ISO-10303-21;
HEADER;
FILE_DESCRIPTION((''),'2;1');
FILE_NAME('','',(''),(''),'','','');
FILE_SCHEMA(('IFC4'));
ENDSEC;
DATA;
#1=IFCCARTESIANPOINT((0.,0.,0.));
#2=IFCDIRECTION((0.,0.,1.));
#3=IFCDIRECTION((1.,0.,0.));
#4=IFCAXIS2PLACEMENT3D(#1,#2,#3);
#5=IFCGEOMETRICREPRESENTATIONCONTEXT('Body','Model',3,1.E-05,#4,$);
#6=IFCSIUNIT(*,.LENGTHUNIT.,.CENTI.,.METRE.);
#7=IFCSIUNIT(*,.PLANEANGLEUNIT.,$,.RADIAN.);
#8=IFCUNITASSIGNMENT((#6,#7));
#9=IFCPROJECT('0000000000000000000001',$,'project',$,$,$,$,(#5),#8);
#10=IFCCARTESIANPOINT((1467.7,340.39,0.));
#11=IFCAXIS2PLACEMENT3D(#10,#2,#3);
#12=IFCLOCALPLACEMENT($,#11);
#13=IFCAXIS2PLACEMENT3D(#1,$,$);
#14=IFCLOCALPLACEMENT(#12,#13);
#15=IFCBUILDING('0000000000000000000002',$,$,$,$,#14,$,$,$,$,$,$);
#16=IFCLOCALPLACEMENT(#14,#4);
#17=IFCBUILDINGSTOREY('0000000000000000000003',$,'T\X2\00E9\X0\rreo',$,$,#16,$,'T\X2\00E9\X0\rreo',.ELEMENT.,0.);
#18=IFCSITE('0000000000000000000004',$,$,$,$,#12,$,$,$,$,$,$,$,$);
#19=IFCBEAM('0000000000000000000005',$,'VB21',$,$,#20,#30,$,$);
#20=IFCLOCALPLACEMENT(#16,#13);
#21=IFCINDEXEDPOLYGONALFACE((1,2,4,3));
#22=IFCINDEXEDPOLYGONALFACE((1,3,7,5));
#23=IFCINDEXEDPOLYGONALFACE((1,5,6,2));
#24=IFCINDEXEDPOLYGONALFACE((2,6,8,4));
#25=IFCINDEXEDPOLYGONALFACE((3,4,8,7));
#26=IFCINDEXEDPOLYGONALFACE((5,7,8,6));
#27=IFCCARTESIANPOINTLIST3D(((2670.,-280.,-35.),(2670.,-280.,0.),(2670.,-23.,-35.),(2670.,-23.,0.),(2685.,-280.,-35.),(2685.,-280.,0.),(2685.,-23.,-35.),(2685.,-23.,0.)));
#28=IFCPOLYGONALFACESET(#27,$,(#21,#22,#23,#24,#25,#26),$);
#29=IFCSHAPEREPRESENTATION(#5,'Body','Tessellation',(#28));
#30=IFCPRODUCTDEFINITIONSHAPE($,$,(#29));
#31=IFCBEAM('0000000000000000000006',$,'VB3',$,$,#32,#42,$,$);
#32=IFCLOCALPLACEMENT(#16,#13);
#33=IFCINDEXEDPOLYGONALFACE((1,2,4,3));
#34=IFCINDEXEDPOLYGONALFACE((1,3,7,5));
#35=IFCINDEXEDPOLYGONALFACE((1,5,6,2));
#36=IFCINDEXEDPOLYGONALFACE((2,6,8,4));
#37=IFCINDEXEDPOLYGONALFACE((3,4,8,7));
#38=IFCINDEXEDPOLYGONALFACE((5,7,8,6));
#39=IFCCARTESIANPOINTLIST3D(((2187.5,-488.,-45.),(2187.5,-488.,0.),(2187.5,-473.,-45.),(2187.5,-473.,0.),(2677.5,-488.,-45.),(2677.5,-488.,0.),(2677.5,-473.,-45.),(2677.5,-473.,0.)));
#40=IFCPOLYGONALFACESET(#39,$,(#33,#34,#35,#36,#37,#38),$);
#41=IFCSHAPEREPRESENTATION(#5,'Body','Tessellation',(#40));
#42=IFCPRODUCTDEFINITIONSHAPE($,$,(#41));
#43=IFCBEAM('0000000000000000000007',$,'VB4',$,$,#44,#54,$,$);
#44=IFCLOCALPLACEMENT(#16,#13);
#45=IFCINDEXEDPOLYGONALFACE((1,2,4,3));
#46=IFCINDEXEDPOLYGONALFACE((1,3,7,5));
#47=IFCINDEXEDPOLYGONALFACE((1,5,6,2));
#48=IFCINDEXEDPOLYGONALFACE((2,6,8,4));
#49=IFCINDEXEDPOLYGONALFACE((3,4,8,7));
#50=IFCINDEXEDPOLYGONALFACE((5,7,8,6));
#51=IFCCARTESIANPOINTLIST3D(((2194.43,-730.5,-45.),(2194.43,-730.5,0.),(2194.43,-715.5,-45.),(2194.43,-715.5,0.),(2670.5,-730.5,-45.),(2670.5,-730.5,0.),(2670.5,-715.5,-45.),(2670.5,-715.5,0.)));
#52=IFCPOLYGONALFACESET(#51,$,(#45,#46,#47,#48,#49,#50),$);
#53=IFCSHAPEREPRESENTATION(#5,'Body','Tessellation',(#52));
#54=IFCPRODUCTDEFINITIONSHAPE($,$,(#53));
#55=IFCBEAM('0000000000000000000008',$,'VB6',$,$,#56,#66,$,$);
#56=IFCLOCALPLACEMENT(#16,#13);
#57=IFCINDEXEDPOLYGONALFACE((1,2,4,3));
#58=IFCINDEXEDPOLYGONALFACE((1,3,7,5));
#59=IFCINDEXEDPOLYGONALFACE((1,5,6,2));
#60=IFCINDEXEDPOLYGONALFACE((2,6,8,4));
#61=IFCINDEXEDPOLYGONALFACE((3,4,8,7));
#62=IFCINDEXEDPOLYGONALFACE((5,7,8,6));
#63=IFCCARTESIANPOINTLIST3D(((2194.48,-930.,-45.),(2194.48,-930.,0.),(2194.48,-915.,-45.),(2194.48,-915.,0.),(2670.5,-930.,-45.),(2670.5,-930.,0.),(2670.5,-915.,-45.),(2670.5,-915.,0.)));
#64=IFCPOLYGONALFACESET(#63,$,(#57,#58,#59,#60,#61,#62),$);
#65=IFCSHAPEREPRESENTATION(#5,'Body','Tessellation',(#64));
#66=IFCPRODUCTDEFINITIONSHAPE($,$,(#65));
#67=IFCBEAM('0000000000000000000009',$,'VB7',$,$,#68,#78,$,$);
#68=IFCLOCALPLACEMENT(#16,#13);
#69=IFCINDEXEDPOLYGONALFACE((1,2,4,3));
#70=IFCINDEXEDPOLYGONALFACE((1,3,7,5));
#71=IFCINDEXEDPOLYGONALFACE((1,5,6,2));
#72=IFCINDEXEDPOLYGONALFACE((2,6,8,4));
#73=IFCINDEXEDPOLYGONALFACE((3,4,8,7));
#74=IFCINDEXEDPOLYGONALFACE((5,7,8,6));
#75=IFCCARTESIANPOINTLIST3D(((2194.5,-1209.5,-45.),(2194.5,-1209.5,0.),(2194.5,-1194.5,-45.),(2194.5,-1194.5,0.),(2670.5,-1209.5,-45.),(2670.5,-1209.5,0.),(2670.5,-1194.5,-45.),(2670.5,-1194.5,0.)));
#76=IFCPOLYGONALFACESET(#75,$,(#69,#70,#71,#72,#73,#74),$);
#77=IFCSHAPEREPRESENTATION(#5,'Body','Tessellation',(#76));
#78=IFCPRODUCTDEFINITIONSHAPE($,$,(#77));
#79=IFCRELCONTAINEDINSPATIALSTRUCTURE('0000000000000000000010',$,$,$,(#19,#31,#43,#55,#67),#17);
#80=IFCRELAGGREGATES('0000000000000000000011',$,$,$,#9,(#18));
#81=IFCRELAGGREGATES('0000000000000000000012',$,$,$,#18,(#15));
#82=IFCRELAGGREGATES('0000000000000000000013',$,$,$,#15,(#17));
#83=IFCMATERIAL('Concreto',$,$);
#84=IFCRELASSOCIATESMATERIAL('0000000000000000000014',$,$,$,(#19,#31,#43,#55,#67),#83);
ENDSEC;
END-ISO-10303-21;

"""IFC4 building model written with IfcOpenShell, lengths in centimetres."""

from ifc_helpers import new_model, si_unit, frame, origin, origin_with_axes, origin_2d_with_axis, place, context, project, spatial, rectangle, extrude, material, element, save


model = new_model("IFC4")

# Units and contexts
model_context = context("Model", 3, precision=1e-05, world=origin_with_axes(), identifier="Body")
ifc_project = project(units=[si_unit("LENGTHUNIT", "METRE", prefix="CENTI"), si_unit("PLANEANGLEUNIT", "RADIAN")], contexts=[model_context])

# Site, building, storey
site_placement = place(None, frame((1467.7, 340.39, 0.0), z_axis=(0.0, 0.0, 1.0), x_axis=(1.0, 0.0, 0.0)))
site = spatial("IfcSite", under=ifc_project, at=site_placement)
building_placement = place(site_placement, origin())
building = spatial("IfcBuilding", under=site, at=building_placement)
storey_placement = place(building_placement, origin_with_axes())
storey = spatial("IfcBuildingStorey", under=building, at=storey_placement, Name="Térreo", LongName="Térreo", CompositionType="ELEMENT", Elevation=0.0)

# Shared definitions
ifc_material = material(Name="Concreto")

# Beams
beam_1_placement = place(storey_placement, frame((2677.5, -151.5, 0.0), z_axis=(0.0, 0.0, 1.0), x_axis=(1.0, 0.0, 0.0)))
element("IfcBeam", 1, at=beam_1_placement, inside=storey, material=ifc_material, Name="VB21", context=model_context, shape_type="SolidModel", body=[
    extrude(rectangle(XDim=15.0, YDim=35.0, at=origin_2d_with_axis()), frame((0.0, -128.5, -17.5), z_axis=(0.0, 1.0, 0.0), x_axis=(1.0, 0.0, 0.0)), (0.0, 0.0, 1.0), 257.0),
])
beam_2_placement = place(storey_placement, frame((2432.5, -480.5, 0.0), z_axis=(0.0, 0.0, 1.0), x_axis=(1.0, 0.0, 0.0)))
element("IfcBeam", 2, at=beam_2_placement, inside=storey, material=ifc_material, Name="VB3", context=model_context, shape_type="SolidModel", body=[
    extrude(rectangle(XDim=15.0, YDim=45.0, at=origin_2d_with_axis()), frame((-245.0, 0.0, -22.5), z_axis=(1.0, 0.0, 0.0), x_axis=(0.0, 1.0, 0.0)), (0.0, 0.0, 1.0), 490.0),
])
beam_3_placement = place(storey_placement, frame((2432.47, -723.0, 0.0), z_axis=(0.0, 0.0, 1.0), x_axis=(1.0, 0.0, 0.0)))
element("IfcBeam", 3, at=beam_3_placement, inside=storey, material=ifc_material, Name="VB4", context=model_context, shape_type="SolidModel", body=[
    extrude(rectangle(XDim=15.0, YDim=45.0, at=origin_2d_with_axis()), frame((-238.03, 0.0, -22.5), z_axis=(1.0, 0.0, 0.0), x_axis=(0.0, 1.0, 0.0)), (0.0, 0.0, 1.0), 476.07),
])
beam_4_placement = place(storey_placement, frame((2432.49, -922.5, 0.0), z_axis=(0.0, 0.0, 1.0), x_axis=(1.0, 0.0, 0.0)))
element("IfcBeam", 4, at=beam_4_placement, inside=storey, material=ifc_material, Name="VB6", context=model_context, shape_type="SolidModel", body=[
    extrude(rectangle(XDim=15.0, YDim=45.0, at=origin_2d_with_axis()), frame((-238.01, 0.0, -22.5), z_axis=(1.0, 0.0, 0.0), x_axis=(0.0, 1.0, 0.0)), (0.0, 0.0, 1.0), 476.02),
])
beam_5_placement = place(storey_placement, frame((2432.5, -1202.0, 0.0), z_axis=(0.0, 0.0, 1.0), x_axis=(1.0, 0.0, 0.0)))
element("IfcBeam", 5, at=beam_5_placement, inside=storey, material=ifc_material, Name="VB7", context=model_context, shape_type="SolidModel", body=[
    extrude(rectangle(XDim=15.0, YDim=45.0, at=origin_2d_with_axis()), frame((-238.0, 0.0, -22.5), z_axis=(1.0, 0.0, 0.0), x_axis=(0.0, 1.0, 0.0)), (0.0, 0.0, 1.0), 476.0),
])

save(model, "model.ifc")
